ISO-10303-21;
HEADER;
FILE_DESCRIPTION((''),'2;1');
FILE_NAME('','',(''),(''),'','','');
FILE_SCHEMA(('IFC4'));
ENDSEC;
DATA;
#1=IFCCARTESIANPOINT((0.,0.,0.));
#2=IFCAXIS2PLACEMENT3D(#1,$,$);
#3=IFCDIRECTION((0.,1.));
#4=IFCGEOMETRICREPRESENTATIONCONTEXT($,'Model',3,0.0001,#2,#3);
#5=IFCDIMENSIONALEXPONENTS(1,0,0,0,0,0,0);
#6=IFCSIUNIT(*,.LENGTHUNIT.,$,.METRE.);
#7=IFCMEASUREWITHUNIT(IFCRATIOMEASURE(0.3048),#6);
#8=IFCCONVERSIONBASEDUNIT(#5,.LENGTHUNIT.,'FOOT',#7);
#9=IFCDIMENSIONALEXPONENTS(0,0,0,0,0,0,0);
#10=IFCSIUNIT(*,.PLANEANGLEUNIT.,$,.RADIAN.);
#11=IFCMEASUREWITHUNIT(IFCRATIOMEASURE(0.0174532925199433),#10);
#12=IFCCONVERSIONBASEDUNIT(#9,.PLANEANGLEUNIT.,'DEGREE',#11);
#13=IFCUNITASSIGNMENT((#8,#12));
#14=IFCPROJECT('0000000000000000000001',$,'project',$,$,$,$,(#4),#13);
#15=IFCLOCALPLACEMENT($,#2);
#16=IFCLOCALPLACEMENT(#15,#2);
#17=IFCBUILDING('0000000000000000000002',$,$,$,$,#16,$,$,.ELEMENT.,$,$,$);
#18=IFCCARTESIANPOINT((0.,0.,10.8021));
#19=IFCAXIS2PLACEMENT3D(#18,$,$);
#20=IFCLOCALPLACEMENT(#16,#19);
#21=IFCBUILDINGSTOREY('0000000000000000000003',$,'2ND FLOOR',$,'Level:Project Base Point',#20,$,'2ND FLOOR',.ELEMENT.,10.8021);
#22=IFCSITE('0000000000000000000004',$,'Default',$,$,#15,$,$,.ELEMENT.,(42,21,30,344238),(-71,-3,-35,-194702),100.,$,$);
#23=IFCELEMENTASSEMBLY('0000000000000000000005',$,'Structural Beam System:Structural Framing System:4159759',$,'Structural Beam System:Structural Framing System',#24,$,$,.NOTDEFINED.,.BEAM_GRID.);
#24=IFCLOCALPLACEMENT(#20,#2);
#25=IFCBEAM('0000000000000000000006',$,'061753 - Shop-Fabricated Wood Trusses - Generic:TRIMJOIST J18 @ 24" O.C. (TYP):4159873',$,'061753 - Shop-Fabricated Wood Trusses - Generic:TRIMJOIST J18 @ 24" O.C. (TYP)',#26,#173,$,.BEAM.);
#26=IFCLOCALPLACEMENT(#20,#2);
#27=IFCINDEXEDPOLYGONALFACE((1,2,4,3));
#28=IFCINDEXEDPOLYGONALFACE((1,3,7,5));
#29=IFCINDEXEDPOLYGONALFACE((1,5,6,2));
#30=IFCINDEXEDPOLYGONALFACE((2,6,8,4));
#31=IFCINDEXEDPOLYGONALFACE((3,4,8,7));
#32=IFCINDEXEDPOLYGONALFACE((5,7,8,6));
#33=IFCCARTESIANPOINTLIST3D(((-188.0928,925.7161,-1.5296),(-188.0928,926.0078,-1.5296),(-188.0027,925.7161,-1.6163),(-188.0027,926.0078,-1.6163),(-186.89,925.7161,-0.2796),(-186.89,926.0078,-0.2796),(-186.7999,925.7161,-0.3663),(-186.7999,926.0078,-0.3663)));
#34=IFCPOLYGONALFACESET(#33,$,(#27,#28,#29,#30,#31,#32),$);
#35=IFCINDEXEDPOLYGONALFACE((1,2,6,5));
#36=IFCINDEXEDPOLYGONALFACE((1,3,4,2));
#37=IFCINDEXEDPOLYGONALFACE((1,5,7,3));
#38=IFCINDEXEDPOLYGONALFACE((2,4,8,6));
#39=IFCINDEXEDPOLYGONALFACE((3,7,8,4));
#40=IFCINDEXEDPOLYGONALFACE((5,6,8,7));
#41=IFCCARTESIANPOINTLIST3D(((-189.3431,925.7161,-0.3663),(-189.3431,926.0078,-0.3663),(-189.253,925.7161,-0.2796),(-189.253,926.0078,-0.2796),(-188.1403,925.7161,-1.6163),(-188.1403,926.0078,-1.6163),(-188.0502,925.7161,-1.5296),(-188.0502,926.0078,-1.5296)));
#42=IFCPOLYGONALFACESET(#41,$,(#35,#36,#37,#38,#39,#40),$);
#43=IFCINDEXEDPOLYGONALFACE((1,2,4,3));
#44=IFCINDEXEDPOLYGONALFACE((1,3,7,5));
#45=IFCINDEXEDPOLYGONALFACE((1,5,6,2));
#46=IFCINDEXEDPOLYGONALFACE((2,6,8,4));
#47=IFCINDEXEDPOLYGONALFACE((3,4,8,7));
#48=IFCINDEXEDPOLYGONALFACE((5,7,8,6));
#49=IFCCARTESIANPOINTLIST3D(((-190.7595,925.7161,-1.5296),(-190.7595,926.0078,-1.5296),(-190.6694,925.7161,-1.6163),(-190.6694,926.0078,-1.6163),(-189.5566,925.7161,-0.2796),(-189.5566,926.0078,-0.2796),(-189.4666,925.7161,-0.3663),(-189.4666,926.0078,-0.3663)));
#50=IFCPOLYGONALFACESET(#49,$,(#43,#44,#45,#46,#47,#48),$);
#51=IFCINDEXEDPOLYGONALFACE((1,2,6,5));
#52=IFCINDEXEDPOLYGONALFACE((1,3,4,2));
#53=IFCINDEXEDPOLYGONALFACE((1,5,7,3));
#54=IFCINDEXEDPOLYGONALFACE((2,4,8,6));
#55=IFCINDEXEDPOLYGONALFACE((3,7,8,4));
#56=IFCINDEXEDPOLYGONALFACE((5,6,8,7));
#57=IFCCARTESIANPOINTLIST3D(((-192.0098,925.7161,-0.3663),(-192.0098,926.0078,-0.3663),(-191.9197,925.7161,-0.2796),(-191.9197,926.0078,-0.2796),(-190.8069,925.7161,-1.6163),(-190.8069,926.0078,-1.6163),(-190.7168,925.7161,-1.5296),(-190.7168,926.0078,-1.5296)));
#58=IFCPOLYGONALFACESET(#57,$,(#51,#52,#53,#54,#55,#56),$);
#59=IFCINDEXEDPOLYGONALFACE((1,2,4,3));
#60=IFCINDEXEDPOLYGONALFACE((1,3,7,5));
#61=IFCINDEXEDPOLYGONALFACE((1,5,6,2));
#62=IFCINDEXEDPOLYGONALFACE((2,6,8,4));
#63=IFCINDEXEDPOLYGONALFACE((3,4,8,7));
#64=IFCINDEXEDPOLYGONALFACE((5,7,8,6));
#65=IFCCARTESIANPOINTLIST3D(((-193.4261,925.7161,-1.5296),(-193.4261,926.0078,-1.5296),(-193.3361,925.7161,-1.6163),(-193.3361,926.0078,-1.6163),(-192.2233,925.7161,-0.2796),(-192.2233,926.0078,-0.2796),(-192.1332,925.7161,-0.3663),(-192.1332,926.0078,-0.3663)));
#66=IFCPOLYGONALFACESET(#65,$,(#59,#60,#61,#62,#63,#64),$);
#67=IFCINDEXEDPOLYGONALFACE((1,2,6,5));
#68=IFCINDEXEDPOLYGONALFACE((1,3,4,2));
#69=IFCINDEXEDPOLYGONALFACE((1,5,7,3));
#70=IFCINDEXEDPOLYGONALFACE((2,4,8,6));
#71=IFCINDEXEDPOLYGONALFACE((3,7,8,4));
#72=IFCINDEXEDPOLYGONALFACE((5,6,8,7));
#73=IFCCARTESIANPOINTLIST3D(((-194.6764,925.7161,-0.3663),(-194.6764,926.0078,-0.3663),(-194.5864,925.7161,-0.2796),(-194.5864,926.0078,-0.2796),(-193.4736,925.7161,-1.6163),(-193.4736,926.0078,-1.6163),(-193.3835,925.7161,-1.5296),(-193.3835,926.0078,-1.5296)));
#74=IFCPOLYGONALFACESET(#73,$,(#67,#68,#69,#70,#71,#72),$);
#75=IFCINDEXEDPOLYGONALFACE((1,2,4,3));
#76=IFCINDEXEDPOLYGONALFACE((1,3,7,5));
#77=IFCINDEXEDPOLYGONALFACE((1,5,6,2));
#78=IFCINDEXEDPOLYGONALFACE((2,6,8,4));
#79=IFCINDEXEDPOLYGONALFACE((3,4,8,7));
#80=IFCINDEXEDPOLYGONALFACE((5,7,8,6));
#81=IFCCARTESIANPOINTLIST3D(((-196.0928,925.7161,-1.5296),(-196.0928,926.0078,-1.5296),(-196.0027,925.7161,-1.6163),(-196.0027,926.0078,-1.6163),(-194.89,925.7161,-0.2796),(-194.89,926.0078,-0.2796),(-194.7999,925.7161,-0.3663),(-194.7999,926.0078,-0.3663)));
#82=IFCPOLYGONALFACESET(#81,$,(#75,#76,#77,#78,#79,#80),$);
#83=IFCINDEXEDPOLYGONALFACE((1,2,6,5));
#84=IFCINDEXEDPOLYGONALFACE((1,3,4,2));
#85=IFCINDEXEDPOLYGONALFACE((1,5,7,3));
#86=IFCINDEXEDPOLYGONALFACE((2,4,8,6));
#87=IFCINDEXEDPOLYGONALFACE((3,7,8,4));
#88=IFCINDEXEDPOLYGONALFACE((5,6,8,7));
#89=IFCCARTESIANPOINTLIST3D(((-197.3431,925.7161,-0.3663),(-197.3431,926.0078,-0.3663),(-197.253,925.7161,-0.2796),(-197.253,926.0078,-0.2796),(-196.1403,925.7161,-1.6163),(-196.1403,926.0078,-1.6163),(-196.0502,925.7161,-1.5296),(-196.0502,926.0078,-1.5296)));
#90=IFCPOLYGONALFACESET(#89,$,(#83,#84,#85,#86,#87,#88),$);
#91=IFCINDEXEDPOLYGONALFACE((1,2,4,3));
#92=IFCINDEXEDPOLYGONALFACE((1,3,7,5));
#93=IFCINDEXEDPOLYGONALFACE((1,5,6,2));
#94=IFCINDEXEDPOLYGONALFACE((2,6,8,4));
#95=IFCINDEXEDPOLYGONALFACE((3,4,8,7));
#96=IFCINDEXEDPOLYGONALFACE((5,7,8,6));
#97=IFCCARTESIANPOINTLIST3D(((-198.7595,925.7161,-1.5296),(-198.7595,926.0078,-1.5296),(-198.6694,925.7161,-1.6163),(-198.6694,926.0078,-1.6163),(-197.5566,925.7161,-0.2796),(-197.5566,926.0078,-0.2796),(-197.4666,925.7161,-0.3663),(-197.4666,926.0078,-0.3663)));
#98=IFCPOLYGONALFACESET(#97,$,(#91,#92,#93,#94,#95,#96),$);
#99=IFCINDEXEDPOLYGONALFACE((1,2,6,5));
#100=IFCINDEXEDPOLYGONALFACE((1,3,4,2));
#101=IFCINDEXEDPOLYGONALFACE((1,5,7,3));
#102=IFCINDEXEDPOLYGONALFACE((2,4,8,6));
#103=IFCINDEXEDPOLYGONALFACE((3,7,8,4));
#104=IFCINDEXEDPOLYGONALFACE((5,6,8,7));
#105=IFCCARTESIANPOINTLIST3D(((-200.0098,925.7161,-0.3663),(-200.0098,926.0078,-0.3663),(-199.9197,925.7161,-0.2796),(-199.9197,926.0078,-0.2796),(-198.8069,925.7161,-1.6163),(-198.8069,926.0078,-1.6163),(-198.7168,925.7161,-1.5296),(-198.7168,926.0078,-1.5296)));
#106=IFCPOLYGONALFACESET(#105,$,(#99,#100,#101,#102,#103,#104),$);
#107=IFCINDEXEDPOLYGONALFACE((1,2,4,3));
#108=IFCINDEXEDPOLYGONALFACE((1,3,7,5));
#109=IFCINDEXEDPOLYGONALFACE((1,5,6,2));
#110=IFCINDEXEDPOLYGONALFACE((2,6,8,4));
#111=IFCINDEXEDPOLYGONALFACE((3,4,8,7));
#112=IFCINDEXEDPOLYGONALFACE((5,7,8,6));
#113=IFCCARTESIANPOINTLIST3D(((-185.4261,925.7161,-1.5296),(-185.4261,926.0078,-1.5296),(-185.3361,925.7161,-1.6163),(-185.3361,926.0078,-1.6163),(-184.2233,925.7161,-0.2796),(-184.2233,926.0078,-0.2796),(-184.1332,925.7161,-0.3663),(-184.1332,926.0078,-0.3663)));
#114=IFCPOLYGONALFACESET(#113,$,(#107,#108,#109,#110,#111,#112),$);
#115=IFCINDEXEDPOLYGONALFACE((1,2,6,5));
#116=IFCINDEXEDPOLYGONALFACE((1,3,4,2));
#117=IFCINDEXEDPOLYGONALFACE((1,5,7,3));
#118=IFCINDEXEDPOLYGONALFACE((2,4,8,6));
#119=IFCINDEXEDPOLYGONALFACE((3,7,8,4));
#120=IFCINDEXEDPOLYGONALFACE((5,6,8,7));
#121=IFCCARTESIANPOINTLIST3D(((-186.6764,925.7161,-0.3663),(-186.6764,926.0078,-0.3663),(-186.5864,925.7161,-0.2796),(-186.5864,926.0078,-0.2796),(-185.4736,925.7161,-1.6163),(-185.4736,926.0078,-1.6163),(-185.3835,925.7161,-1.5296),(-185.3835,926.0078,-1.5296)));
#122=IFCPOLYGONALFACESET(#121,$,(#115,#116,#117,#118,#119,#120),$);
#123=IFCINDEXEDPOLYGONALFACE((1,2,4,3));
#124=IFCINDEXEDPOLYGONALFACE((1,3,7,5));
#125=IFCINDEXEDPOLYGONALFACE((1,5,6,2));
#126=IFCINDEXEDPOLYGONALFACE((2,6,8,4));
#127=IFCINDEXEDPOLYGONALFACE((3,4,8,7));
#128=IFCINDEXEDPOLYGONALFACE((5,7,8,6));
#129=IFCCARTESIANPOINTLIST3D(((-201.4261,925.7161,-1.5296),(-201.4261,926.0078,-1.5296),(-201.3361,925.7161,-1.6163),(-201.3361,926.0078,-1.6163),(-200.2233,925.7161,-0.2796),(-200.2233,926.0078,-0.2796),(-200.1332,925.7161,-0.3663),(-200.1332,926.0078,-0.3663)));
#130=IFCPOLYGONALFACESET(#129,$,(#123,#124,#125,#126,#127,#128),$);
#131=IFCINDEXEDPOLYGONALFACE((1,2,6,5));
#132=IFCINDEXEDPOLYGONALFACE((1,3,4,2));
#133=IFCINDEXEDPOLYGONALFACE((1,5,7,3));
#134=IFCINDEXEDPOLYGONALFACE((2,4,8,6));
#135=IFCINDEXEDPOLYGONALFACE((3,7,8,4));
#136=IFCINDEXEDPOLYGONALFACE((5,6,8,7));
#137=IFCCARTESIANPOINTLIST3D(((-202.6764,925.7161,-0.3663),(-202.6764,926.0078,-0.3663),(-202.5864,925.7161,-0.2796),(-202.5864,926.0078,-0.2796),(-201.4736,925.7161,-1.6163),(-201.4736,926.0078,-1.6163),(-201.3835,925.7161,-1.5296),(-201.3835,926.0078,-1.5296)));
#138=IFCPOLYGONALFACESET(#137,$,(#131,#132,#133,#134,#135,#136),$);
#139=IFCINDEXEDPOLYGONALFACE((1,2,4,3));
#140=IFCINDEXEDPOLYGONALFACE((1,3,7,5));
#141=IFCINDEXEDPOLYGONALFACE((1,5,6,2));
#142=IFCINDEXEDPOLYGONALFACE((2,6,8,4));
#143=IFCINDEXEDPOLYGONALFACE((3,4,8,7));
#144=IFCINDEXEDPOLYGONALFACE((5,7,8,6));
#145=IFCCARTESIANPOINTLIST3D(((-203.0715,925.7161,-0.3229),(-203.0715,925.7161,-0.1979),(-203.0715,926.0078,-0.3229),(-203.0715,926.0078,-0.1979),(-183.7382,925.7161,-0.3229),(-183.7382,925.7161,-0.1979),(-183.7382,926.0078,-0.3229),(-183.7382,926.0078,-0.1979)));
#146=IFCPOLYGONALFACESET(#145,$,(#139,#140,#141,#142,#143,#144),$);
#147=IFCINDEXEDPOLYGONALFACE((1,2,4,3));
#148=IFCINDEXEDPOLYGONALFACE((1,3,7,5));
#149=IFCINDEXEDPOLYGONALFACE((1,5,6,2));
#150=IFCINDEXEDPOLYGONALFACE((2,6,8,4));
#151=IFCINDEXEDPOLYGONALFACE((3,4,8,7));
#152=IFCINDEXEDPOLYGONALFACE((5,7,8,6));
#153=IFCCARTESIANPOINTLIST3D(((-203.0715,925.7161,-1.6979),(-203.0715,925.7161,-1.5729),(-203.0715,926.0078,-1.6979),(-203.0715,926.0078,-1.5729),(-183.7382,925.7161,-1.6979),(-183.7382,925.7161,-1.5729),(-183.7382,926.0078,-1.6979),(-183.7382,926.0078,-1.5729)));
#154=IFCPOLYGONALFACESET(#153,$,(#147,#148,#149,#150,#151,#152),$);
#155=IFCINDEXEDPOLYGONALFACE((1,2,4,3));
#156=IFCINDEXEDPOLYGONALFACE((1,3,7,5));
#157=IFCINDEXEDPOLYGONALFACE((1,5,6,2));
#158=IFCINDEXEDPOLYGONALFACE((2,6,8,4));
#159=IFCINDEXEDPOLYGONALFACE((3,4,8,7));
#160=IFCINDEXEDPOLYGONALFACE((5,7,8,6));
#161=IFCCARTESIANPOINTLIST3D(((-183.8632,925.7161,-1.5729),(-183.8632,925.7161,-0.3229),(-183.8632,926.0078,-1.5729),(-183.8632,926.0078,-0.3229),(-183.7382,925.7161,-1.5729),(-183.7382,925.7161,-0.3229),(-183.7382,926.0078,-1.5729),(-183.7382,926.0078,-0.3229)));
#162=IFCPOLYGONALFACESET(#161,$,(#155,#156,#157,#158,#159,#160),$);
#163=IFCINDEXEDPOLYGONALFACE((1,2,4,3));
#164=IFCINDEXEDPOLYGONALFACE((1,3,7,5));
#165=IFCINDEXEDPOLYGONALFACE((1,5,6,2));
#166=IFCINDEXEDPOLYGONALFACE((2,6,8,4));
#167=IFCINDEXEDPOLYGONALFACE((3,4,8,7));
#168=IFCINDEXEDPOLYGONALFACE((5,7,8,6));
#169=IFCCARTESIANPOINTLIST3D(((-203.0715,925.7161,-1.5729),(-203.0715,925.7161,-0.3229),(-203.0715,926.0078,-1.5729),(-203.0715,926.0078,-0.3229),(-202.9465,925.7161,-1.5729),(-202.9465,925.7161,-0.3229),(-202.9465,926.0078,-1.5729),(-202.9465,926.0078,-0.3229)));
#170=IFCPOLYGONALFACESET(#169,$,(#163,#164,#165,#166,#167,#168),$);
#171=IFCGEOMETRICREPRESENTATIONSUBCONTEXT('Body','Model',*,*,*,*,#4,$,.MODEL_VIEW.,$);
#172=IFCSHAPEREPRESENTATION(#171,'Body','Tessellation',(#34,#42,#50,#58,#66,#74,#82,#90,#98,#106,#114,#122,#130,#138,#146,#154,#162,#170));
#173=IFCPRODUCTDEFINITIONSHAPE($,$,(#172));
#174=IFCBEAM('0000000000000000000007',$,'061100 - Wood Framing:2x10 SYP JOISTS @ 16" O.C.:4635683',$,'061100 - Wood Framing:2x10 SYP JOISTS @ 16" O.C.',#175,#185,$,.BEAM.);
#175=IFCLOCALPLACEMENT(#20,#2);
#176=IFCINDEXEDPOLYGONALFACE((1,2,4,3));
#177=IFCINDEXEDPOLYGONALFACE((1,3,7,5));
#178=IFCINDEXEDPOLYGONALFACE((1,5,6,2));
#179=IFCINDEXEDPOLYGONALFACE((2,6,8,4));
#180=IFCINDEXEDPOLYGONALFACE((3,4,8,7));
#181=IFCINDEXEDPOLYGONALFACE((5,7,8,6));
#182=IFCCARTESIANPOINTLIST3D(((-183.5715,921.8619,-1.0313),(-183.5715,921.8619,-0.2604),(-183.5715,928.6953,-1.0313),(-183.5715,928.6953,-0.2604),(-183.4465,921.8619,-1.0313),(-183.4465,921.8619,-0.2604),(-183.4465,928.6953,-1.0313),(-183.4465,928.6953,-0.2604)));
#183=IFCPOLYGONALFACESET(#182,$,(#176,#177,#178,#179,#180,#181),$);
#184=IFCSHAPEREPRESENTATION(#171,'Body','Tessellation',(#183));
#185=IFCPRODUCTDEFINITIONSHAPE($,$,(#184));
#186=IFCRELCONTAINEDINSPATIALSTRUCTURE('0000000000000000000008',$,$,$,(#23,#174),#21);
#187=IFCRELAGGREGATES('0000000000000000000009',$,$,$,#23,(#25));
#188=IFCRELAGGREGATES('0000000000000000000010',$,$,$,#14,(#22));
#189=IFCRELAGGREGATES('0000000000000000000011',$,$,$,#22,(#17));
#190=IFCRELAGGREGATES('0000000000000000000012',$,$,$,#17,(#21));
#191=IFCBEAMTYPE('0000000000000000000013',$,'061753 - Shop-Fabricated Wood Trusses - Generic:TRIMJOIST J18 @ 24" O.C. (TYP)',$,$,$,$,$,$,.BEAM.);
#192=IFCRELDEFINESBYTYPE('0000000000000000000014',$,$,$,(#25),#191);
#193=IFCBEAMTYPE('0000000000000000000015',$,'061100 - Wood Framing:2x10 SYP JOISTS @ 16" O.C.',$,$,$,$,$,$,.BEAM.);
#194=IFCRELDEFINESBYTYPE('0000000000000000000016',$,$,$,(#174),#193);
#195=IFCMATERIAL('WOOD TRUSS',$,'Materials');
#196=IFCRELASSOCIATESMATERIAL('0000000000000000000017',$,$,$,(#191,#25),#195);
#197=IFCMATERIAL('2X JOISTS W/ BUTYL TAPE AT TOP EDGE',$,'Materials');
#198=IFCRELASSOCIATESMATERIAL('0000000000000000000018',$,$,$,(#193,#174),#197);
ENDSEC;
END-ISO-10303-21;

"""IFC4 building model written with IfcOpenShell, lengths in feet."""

from ifc_helpers import new_model, entity, si_unit, converted_unit, direction, frame, frame_2d, origin, origin_2d_with_axis, place, context, subcontext, project, spatial, rectangle, extrude, source, transform, mapped, material, material_profile, profile_set, profile_usage, type_object, type_shapes, element, aggregate, save


model = new_model("IFC4")

# Units and contexts
model_context = context("Model", 3, precision=0.0001, world=origin(), true_north=direction((0.0, 1.0)))
body_context = subcontext(model_context, "Body", "Model", "MODEL_VIEW")
ifc_project = project(units=[converted_unit("LENGTHUNIT", "FOOT", entity("IfcRatioMeasure", 0.3048), si_unit("LENGTHUNIT", "METRE"), dimensions=[1, 0, 0, 0, 0, 0, 0]), converted_unit("PLANEANGLEUNIT", "DEGREE", entity("IfcRatioMeasure", 0.0174532925199433), si_unit("PLANEANGLEUNIT", "RADIAN"), dimensions=[0, 0, 0, 0, 0, 0, 0])], contexts=[model_context])

# Site, building, storey
site_placement = place(None, origin())
site = spatial("IfcSite", under=ifc_project, at=site_placement, Name="Default", CompositionType="ELEMENT", RefLatitude=(42, 21, 30, 344238), RefLongitude=(-71, -3, -35, -194702), RefElevation=100.0)
building_placement = place(site_placement, origin())
building = spatial("IfcBuilding", under=site, at=building_placement, CompositionType="ELEMENT")
storey_placement = place(building_placement, frame((0.0, 0.0, 10.8021)))
storey = spatial("IfcBuildingStorey", under=building, at=storey_placement, Name="2ND FLOOR", ObjectType="Level:Project Base Point", LongName="2ND FLOOR", CompositionType="ELEMENT", Elevation=10.8021)

# Shared definitions
ifc_material_1 = material(Name="2X JOISTS W/ BUTYL TAPE AT TOP EDGE", Category="Materials")
ifc_material_profile_1 = material_profile(ifc_material_1, rectangle(XDim=0.7708, YDim=0.125, at=frame_2d((0.0, 0.0), x_axis=(1.0, 0.0))), Name="2x10 SYP JOISTS @ 16\" O.C.")
ifc_profile_set_1 = profile_set([ifc_material_profile_1], Name="2x10 SYP JOISTS @ 16\" O.C.")

# Element assembly, beam
ifc_material_2 = material(Name="WOOD TRUSS", Category="Materials")
ifc_material_profile_2 = material_profile(ifc_material_2, rectangle(XDim=1.7347, YDim=0.125, at=frame_2d((0.0, 0.0), x_axis=(1.0, 0.0))), Name="TRIMJOIST J18 @ 24\" O.C. (TYP)")
ifc_material_profile_3 = material_profile(ifc_material_2, rectangle(XDim=1.7347, YDim=0.125, at=frame_2d((0.0, 0.0), x_axis=(1.0, 0.0))), Name="TRIMJOIST J18 @ 24\" O.C. (TYP)")
ifc_material_profile_4 = material_profile(ifc_material_2, rectangle(XDim=1.7347, YDim=0.125, at=frame_2d((0.0, 0.0), x_axis=(1.0, 0.0))), Name="TRIMJOIST J18 @ 24\" O.C. (TYP)")
ifc_material_profile_5 = material_profile(ifc_material_2, rectangle(XDim=1.7347, YDim=0.125, at=frame_2d((0.0, 0.0), x_axis=(1.0, 0.0))), Name="TRIMJOIST J18 @ 24\" O.C. (TYP)")
ifc_material_profile_6 = material_profile(ifc_material_2, rectangle(XDim=1.7347, YDim=0.125, at=frame_2d((0.0, 0.0), x_axis=(1.0, 0.0))), Name="TRIMJOIST J18 @ 24\" O.C. (TYP)")
ifc_material_profile_7 = material_profile(ifc_material_2, rectangle(XDim=1.7347, YDim=0.125, at=frame_2d((0.0, 0.0), x_axis=(1.0, 0.0))), Name="TRIMJOIST J18 @ 24\" O.C. (TYP)")
ifc_material_profile_8 = material_profile(ifc_material_2, rectangle(XDim=1.7347, YDim=0.125, at=frame_2d((0.0, 0.0), x_axis=(1.0, 0.0))), Name="TRIMJOIST J18 @ 24\" O.C. (TYP)")
ifc_material_profile_9 = material_profile(ifc_material_2, rectangle(XDim=1.7347, YDim=0.125, at=frame_2d((0.0, 0.0), x_axis=(1.0, 0.0))), Name="TRIMJOIST J18 @ 24\" O.C. (TYP)")
ifc_material_profile_10 = material_profile(ifc_material_2, rectangle(XDim=1.7347, YDim=0.125, at=frame_2d((0.0, 0.0), x_axis=(1.0, 0.0))), Name="TRIMJOIST J18 @ 24\" O.C. (TYP)")
ifc_material_profile_11 = material_profile(ifc_material_2, rectangle(XDim=1.7347, YDim=0.125, at=origin_2d_with_axis()), Name="TRIMJOIST J18 @ 24\" O.C. (TYP)")
ifc_material_profile_12 = material_profile(ifc_material_2, rectangle(XDim=0.125, YDim=0.2917, at=origin_2d_with_axis()), Name="TRIMJOIST J18 @ 24\" O.C. (TYP)")
ifc_material_profile_13 = material_profile(ifc_material_2, rectangle(XDim=0.125, YDim=0.2917, at=origin_2d_with_axis()), Name="TRIMJOIST J18 @ 24\" O.C. (TYP)")
ifc_material_profile_14 = material_profile(ifc_material_2, rectangle(XDim=1.25, YDim=0.2917, at=origin_2d_with_axis()), Name="TRIMJOIST J18 @ 24\" O.C. (TYP)")
ifc_material_profile_15 = material_profile(ifc_material_2, rectangle(XDim=1.25, YDim=0.2917, at=origin_2d_with_axis()), Name="TRIMJOIST J18 @ 24\" O.C. (TYP)")
ifc_profile_set_2 = profile_set([ifc_material_profile_2, ifc_material_profile_3, ifc_material_profile_4, ifc_material_profile_5, ifc_material_profile_6, ifc_material_profile_7, ifc_material_profile_8, ifc_material_profile_9, ifc_material_profile_10, ifc_material_profile_11, ifc_material_profile_12, ifc_material_profile_13, ifc_material_profile_14, ifc_material_profile_15], Name="TRIMJOIST J18 @ 24\" O.C. (TYP)")
assembly_1_placement = place(storey_placement, origin())
assembly_1 = element("IfcElementAssembly", 1, at=assembly_1_placement, inside=storey, Name="Structural Beam System:Structural Framing System:4159759", ObjectType="Structural Beam System:Structural Framing System", AssemblyPlace="NOTDEFINED", PredefinedType="BEAM_GRID")
ifc_profile_usage_1 = profile_usage(ifc_profile_set_2, cardinal=8)
beam_type_1 = type_object("IfcBeamType", Name="061753 - Shop-Fabricated Wood Trusses - Generic:TRIMJOIST J18 @ 24\" O.C. (TYP)", PredefinedType="BEAM", material=ifc_profile_set_2)
shared_shape_1 = source(origin(), body_context, "Body", "SweptSolid", [
    extrude(rectangle(XDim=1.7347, YDim=0.125, at=frame_2d((0.0, 0.0), x_axis=(1.0, 0.0))), frame((5.9585, -0.1458, 0.0), z_axis=(0.0, 1.0, 0.0), x_axis=(0.693383, 0.0, 0.720569)), (0.0, 0.0, 1.0), 0.2917),
    extrude(rectangle(XDim=1.7347, YDim=0.125, at=origin_2d_with_axis()), frame((4.7082, -0.1458, 0.0), z_axis=(0.0, 1.0, 0.0), x_axis=(0.693383, 0.0, -0.720569)), (0.0, 0.0, 1.0), 0.2917),
    extrude(rectangle(XDim=1.7347, YDim=0.125, at=frame_2d((0.0, 0.0), x_axis=(1.0, 0.0))), frame((3.2918, -0.1458, 0.0), z_axis=(0.0, 1.0, 0.0), x_axis=(0.693383, 0.0, 0.720569)), (0.0, 0.0, 1.0), 0.2917),
    extrude(rectangle(XDim=1.7347, YDim=0.125, at=frame_2d((0.0, 0.0), x_axis=(1.0, 0.0))), frame((2.0415, -0.1458, 0.0), z_axis=(0.0, 1.0, 0.0), x_axis=(0.693383, 0.0, -0.720569)), (0.0, 0.0, 1.0), 0.2917),
    extrude(rectangle(XDim=1.7347, YDim=0.125, at=frame_2d((0.0, 0.0), x_axis=(1.0, 0.0))), frame((0.6251, -0.1458, 0.0), z_axis=(0.0, 1.0, 0.0), x_axis=(0.693383, 0.0, 0.720569)), (0.0, 0.0, 1.0), 0.2917),
    extrude(rectangle(XDim=1.7347, YDim=0.125, at=frame_2d((0.0, 0.0), x_axis=(1.0, 0.0))), frame((-0.6251, -0.1458, 0.0), z_axis=(0.0, 1.0, 0.0), x_axis=(0.693383, 0.0, -0.720569)), (0.0, 0.0, 1.0), 0.2917),
    extrude(rectangle(XDim=1.7347, YDim=0.125, at=frame_2d((0.0, 0.0), x_axis=(1.0, 0.0))), frame((-2.0415, -0.1458, 0.0), z_axis=(0.0, 1.0, 0.0), x_axis=(0.693383, 0.0, 0.720569)), (0.0, 0.0, 1.0), 0.2917),
    extrude(rectangle(XDim=1.7347, YDim=0.125, at=origin_2d_with_axis()), frame((-3.2918, -0.1458, 0.0), z_axis=(0.0, 1.0, 0.0), x_axis=(0.693383, 0.0, -0.720569)), (0.0, 0.0, 1.0), 0.2917),
    extrude(rectangle(XDim=1.7347, YDim=0.125, at=frame_2d((0.0, 0.0), x_axis=(1.0, 0.0))), frame((-4.7082, -0.1458, 0.0), z_axis=(0.0, 1.0, 0.0), x_axis=(0.693383, 0.0, 0.720569)), (0.0, 0.0, 1.0), 0.2917),
    extrude(rectangle(XDim=1.7347, YDim=0.125, at=frame_2d((0.0, 0.0), x_axis=(1.0, 0.0))), frame((-5.9585, -0.1458, 0.0), z_axis=(0.0, 1.0, 0.0), x_axis=(0.693383, 0.0, -0.720569)), (0.0, 0.0, 1.0), 0.2917),
    extrude(rectangle(XDim=1.7347, YDim=0.125, at=frame_2d((0.0, 0.0), x_axis=(1.0, 0.0))), frame((8.6251, -0.1458, 0.0), z_axis=(0.0, 1.0, 0.0), x_axis=(0.693383, 0.0, 0.720569)), (0.0, 0.0, 1.0), 0.2917),
    extrude(rectangle(XDim=1.7347, YDim=0.125, at=origin_2d_with_axis()), frame((7.3749, -0.1458, 0.0), z_axis=(0.0, 1.0, 0.0), x_axis=(0.693383, 0.0, -0.720569)), (0.0, 0.0, 1.0), 0.2917),
    extrude(rectangle(XDim=1.7347, YDim=0.125, at=frame_2d((0.0, 0.0), x_axis=(1.0, 0.0))), frame((-7.3749, -0.1458, 0.0), z_axis=(0.0, 1.0, 0.0), x_axis=(0.693383, 0.0, 0.720569)), (0.0, 0.0, 1.0), 0.2917),
    extrude(rectangle(XDim=1.7347, YDim=0.125, at=origin_2d_with_axis()), frame((-8.6251, -0.1458, 0.0), z_axis=(0.0, 1.0, 0.0), x_axis=(0.693383, 0.0, -0.720569)), (0.0, 0.0, 1.0), 0.2917),
    extrude(rectangle(XDim=0.125, YDim=0.2917, at=origin_2d_with_axis()), frame((-9.6667, 0.0, 0.6875), z_axis=(1.0, 0.0, 0.0), x_axis=(0.0, 0.0, -1.0)), (0.0, 0.0, 1.0), 19.3333),
    extrude(rectangle(XDim=0.125, YDim=0.2917, at=origin_2d_with_axis()), frame((-9.6667, 0.0, -0.6875), z_axis=(1.0, 0.0, 0.0), x_axis=(0.0, 0.0, -1.0)), (0.0, 0.0, 1.0), 19.3333),
    extrude(rectangle(XDim=1.25, YDim=0.2917, at=origin_2d_with_axis()), frame((9.5417, 0.0, 0.0), z_axis=(1.0, 0.0, 0.0), x_axis=(0.0, 0.0, -1.0)), (0.0, 0.0, 1.0), 0.125),
    extrude(rectangle(XDim=1.25, YDim=0.2917, at=origin_2d_with_axis()), frame((-9.6667, 0.0, 0.0), z_axis=(1.0, 0.0, 0.0), x_axis=(0.0, 0.0, -1.0)), (0.0, 0.0, 1.0), 0.125),
])
type_shapes(beam_type_1, [shared_shape_1])
beam_1_placement = place(assembly_1_placement, frame((-193.4048, 925.8619, -0.9479)))
beam_1 = element("IfcBeam", 2, at=beam_1_placement, type_object=beam_type_1, material=ifc_profile_usage_1, Name="061753 - Shop-Fabricated Wood Trusses - Generic:TRIMJOIST J18 @ 24\" O.C. (TYP):4159873", ObjectType="061753 - Shop-Fabricated Wood Trusses - Generic:TRIMJOIST J18 @ 24\" O.C. (TYP)", PredefinedType="BEAM", context=body_context, shape_type="MappedRepresentation", body=[
    mapped(shared_shape_1, transform((0.0, 0.0, 0.0), scale=1.0)),
])
aggregate(assembly_1, [beam_1])

# Beam
ifc_profile_usage_2 = profile_usage(ifc_profile_set_1, cardinal=8)
beam_type_2 = type_object("IfcBeamType", Name="061100 - Wood Framing:2x10 SYP JOISTS @ 16\" O.C.", PredefinedType="BEAM", material=ifc_profile_set_1)
shared_shape_2 = source(origin(), body_context, "Body", "SweptSolid", [
    extrude(rectangle(XDim=0.7708, YDim=0.125, at=frame_2d((0.0, 0.0), x_axis=(1.0, 0.0))), frame((-3.4792, 0.0, 0.0), z_axis=(1.0, 0.0, 0.0), x_axis=(0.0, 0.0, -1.0)), (0.0, 0.0, 1.0), 6.8333),
])
type_shapes(beam_type_2, [shared_shape_2])
beam_2_placement = place(storey_placement, frame((-183.509, 925.3411, -0.6458), z_axis=(0.0, 0.0, 1.0), x_axis=(0.0, 1.0, 0.0)))
element("IfcBeam", 3, at=beam_2_placement, inside=storey, type_object=beam_type_2, material=ifc_profile_usage_2, Name="061100 - Wood Framing:2x10 SYP JOISTS @ 16\" O.C.:4635683", ObjectType="061100 - Wood Framing:2x10 SYP JOISTS @ 16\" O.C.", PredefinedType="BEAM", context=body_context, shape_type="MappedRepresentation", body=[
    mapped(shared_shape_2, transform((0.0, 0.0, 0.0), scale=1.0)),
])

save(model, "model.ifc")
